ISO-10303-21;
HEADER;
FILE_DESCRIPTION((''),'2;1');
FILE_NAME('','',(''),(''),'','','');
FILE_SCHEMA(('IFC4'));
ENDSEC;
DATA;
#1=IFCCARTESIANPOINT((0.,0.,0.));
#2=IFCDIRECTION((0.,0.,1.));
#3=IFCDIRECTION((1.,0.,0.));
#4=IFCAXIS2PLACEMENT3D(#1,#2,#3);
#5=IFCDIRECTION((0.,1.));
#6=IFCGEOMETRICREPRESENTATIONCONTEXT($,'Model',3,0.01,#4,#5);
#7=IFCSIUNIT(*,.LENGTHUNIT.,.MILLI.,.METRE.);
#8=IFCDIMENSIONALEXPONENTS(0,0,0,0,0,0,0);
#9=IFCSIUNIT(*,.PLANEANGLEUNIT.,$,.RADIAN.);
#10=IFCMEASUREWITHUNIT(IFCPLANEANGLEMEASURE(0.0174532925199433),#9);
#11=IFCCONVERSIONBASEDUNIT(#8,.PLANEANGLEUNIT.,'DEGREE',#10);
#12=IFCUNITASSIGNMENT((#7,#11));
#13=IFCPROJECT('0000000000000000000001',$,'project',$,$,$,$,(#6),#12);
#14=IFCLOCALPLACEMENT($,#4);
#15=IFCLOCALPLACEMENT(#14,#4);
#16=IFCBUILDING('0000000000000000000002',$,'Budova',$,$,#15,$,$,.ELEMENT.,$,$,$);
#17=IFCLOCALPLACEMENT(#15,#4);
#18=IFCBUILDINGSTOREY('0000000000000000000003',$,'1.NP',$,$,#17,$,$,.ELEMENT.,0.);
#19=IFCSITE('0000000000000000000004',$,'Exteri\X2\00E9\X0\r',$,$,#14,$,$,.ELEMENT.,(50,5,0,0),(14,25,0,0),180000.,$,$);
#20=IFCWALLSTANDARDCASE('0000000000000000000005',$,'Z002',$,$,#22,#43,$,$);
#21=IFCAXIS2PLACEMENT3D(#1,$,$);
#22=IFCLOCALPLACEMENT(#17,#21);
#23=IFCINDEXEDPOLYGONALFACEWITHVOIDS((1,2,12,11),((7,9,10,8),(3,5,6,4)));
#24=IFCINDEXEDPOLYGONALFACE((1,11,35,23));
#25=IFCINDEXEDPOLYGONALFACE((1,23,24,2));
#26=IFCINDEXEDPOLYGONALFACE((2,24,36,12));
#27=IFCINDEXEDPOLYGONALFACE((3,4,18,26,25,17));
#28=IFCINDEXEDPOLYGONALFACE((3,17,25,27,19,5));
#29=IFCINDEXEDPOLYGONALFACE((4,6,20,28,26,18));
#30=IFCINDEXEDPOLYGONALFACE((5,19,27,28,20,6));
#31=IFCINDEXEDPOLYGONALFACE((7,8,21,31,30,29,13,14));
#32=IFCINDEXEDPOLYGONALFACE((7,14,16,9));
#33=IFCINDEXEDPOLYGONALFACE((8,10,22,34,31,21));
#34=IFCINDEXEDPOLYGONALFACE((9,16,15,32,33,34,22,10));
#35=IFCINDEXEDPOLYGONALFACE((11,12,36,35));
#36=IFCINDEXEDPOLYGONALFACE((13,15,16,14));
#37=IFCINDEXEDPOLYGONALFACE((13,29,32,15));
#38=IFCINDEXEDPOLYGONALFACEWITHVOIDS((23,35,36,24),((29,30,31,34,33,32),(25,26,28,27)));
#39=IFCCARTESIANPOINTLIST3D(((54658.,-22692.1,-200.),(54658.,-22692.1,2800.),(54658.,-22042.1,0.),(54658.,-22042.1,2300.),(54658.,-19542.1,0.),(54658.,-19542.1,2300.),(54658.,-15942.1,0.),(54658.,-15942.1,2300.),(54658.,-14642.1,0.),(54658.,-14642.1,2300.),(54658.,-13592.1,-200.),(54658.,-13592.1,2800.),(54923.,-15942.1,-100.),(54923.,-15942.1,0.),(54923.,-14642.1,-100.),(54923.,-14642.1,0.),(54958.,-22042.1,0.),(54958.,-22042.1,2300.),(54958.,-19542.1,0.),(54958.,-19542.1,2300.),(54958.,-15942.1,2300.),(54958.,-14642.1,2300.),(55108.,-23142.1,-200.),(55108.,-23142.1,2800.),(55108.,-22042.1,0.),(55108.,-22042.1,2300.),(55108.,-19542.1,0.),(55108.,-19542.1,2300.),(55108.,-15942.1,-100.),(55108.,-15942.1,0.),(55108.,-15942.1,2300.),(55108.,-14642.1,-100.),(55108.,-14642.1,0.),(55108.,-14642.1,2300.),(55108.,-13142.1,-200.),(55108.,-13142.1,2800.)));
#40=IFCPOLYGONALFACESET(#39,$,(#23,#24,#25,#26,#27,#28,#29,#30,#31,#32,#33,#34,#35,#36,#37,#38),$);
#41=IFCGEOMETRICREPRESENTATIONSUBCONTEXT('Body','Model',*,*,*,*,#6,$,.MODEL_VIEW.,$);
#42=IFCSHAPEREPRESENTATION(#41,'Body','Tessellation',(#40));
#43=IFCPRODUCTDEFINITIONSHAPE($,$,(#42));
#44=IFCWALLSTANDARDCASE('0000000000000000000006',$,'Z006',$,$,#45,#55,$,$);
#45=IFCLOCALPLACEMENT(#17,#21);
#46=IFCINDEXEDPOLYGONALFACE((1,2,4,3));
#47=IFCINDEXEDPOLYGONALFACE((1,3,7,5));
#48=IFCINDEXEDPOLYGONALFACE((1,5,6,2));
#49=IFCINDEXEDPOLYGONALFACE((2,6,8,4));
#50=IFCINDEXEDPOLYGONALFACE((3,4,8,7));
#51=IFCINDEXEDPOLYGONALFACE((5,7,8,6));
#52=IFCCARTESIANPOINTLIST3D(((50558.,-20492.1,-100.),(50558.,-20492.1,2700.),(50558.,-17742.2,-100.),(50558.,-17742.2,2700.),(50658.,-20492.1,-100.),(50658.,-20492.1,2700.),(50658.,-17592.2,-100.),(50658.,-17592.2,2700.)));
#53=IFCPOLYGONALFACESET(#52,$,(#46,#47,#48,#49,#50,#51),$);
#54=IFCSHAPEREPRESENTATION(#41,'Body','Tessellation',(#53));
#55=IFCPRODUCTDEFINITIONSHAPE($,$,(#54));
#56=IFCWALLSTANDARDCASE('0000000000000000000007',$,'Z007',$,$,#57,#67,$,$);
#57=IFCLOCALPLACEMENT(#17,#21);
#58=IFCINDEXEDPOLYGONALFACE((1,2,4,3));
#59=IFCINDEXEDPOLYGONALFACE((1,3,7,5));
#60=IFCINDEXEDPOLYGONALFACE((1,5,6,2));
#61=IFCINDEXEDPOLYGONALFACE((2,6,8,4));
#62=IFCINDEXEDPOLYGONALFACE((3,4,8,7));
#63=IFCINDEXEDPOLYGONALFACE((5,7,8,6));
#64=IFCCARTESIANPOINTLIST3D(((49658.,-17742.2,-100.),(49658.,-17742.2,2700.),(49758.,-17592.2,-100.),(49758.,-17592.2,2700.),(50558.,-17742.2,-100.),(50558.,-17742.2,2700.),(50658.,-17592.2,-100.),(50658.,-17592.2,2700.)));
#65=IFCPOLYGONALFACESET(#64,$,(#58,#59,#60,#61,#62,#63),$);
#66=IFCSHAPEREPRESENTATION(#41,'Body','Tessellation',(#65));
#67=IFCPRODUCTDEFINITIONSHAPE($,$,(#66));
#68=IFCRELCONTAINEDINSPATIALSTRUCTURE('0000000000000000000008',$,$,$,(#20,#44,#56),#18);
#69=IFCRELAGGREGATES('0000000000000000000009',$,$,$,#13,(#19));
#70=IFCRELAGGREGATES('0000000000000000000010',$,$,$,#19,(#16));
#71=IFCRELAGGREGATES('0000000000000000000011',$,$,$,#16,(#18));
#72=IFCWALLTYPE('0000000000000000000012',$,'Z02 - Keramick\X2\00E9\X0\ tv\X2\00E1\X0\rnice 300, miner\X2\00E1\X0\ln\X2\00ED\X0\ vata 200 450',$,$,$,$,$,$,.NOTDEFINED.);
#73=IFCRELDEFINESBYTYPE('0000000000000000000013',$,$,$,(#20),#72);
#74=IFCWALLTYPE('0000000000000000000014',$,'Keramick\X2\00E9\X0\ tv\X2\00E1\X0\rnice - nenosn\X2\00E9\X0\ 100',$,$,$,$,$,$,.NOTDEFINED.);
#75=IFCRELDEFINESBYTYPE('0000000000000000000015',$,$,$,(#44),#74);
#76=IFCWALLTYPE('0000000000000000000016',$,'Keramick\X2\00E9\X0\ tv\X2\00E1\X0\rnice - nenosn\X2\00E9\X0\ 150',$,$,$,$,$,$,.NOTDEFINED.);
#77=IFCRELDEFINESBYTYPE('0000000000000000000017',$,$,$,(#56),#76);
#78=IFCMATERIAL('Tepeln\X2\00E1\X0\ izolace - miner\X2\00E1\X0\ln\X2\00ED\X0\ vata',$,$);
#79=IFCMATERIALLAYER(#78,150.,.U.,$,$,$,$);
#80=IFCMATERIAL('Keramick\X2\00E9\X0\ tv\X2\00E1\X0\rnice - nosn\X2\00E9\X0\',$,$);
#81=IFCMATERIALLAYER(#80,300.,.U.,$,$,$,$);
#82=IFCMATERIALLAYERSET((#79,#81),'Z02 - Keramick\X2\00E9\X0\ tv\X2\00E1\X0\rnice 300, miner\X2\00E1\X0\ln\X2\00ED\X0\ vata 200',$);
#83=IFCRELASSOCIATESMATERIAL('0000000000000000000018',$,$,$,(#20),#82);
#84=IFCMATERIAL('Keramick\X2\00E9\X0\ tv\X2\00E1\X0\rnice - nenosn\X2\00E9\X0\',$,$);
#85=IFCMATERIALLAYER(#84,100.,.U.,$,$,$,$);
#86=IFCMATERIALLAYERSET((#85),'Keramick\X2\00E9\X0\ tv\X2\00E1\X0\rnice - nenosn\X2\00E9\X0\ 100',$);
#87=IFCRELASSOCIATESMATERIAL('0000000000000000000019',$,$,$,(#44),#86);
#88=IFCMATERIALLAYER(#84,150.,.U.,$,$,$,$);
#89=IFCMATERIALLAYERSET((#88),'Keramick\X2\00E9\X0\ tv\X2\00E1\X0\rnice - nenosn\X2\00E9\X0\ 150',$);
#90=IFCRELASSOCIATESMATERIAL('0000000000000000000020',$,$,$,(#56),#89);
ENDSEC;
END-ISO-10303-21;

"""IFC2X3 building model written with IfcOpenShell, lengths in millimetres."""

from ifc_helpers import new_model, entity, si_unit, converted_unit, direction, frame, origin_with_axes, origin_2d_with_axis, place, context, subcontext, project, spatial, polyline, rectangle, outline, extrude, material, layer, layer_set, layer_usage, type_object, element, save


model = new_model("IFC2X3")

# Units and contexts
model_context = context("Model", 3, precision=0.01, world=origin_with_axes(), true_north=direction((0.0, 1.0)))
body_context = subcontext(model_context, "Body", "Model", "MODEL_VIEW")
ifc_project = project(units=[si_unit("LENGTHUNIT", "METRE", prefix="MILLI"), converted_unit("PLANEANGLEUNIT", "DEGREE", entity("IfcPlaneAngleMeasure", 0.0174532925199433), si_unit("PLANEANGLEUNIT", "RADIAN"), dimensions=[0, 0, 0, 0, 0, 0, 0])], contexts=[model_context])

# Site, building, storey
site_placement = place(None, origin_with_axes())
site = spatial("IfcSite", under=ifc_project, at=site_placement, Name="Exteriér", CompositionType="ELEMENT", RefLatitude=(50, 5, 0, 0), RefLongitude=(14, 25, 0, 0), RefElevation=180000.0)
building_placement = place(site_placement, origin_with_axes())
building = spatial("IfcBuilding", under=site, at=building_placement, Name="Budova", CompositionType="ELEMENT")
storey_placement = place(building_placement, origin_with_axes())
storey = spatial("IfcBuildingStorey", under=building, at=storey_placement, Name="1.NP", CompositionType="ELEMENT", Elevation=0.0)

# Wall, openings
ifc_material_1 = material(Name="Tepelná izolace - minerální vata")
ifc_layer_1 = layer(ifc_material_1, 150.0, ventilated="UNKNOWN")
ifc_material_2 = material(Name="Keramické tvárnice - nosné")
ifc_layer_2 = layer(ifc_material_2, 300.0, ventilated="UNKNOWN")
ifc_layer_set_1 = layer_set([ifc_layer_1, ifc_layer_2], Name="Z02 - Keramické tvárnice 300, minerální vata 200")
ifc_layer_usage_1 = layer_usage(ifc_layer_set_1, "AXIS2", "NEGATIVE", 0.0)
wall_type_1 = type_object("IfcWallType", Name="Z02 - Keramické tvárnice 300, minerální vata 200 450", PredefinedType="NOTDEFINED")
wall_1_placement = place(storey_placement, frame((55108.0, -13142.1, -200.0), z_axis=(0.0, 0.0, 1.0), x_axis=(0.0, -1.0, 0.0)))
wall_1 = element("IfcWallStandardCase", 1, at=wall_1_placement, inside=storey, type_object=wall_type_1, material=ifc_layer_usage_1, Name="Z002", context=body_context, shape_type="SweptSolid", body=[
    extrude(outline(polyline([(450.0, -450.0), (9550.0, -450.0), (10000.0, 0.0), (0.0, 0.0), (450.0, -450.0)])), origin_with_axes(), (0.0, 0.0, 1.0), 3000.0),
])
opening_1_placement = place(wall_1_placement, frame((2150.0, 0.0, 200.0), z_axis=(0.0, 0.0, 1.0), x_axis=(1.0, 0.0, 0.0)))
element("IfcOpeningElement", 2, at=opening_1_placement, cuts=wall_1, context=body_context, shape_type="SweptSolid", body=[
    extrude(rectangle(XDim=1300.0, YDim=2300.0, at=origin_2d_with_axis()), frame((0.0, -150.0, 1150.0), z_axis=(0.0, 1.0, 0.0), x_axis=(-1.0, 0.0, 0.0)), (0.0, 0.0, -1.0), 750.0),
    extrude(rectangle(XDim=1300.0, YDim=2300.0, at=origin_2d_with_axis()), frame((0.0, -150.0, 1150.0), z_axis=(0.0, -1.0, 0.0), x_axis=(-1.0, 0.0, 0.0)), (0.0, 0.0, -1.0), 600.0),
    extrude(rectangle(XDim=1300.0, YDim=100.0, at=origin_2d_with_axis()), frame((0.0, -185.0, -50.0), z_axis=(0.0, -1.0, 0.0), x_axis=(-1.0, 0.0, 0.0)), (0.0, 0.0, -1.0), 485.0),
])
opening_2_placement = place(wall_1_placement, frame((7650.0, 0.0, 200.0), z_axis=(0.0, 0.0, 1.0), x_axis=(1.0, 0.0, 0.0)))
element("IfcOpeningElement", 3, at=opening_2_placement, cuts=wall_1, context=body_context, shape_type="SweptSolid", body=[
    extrude(rectangle(XDim=2500.0, YDim=2300.0, at=origin_2d_with_axis()), frame((0.0, -150.0, 1150.0), z_axis=(0.0, 1.0, 0.0), x_axis=(-1.0, 0.0, 0.0)), (0.0, 0.0, -1.0), 750.0),
    extrude(rectangle(XDim=2500.0, YDim=2300.0, at=origin_2d_with_axis()), frame((0.0, -150.0, 1150.0), z_axis=(0.0, -1.0, 0.0), x_axis=(-1.0, 0.0, 0.0)), (0.0, 0.0, -1.0), 600.0),
])

# Shared definitions
ifc_material_3 = material(Name="Keramické tvárnice - nenosné")
ifc_layer_3 = layer(ifc_material_3, 100.0, ventilated="UNKNOWN")
ifc_layer_set_2 = layer_set([ifc_layer_3], Name="Keramické tvárnice - nenosné 100")
wall_type_2 = type_object("IfcWallType", Name="Keramické tvárnice - nenosné 100", PredefinedType="NOTDEFINED")

# Wall
ifc_layer_usage_2 = layer_usage(ifc_layer_set_2, "AXIS2", "POSITIVE", 0.0)
wall_2_placement = place(storey_placement, frame((50558.0, -17592.2, -100.0), z_axis=(0.0, 0.0, 1.0), x_axis=(0.0, -1.0, 0.0)))
element("IfcWallStandardCase", 4, at=wall_2_placement, inside=storey, type_object=wall_type_2, material=ifc_layer_usage_2, Name="Z006", context=body_context, shape_type="SweptSolid", body=[
    extrude(outline(polyline([(150.0, 0.0), (2899.8, 0.0), (2899.8, 100.0), (0.0, 100.0), (150.0, 0.0)])), origin_with_axes(), (0.0, 0.0, 1.0), 2800.0),
])

# Wall
ifc_layer_4 = layer(ifc_material_3, 150.0, ventilated="UNKNOWN")
ifc_layer_set_3 = layer_set([ifc_layer_4], Name="Keramické tvárnice - nenosné 150")
ifc_layer_usage_3 = layer_usage(ifc_layer_set_3, "AXIS2", "NEGATIVE", 0.0)
wall_type_3 = type_object("IfcWallType", Name="Keramické tvárnice - nenosné 150", PredefinedType="NOTDEFINED")
wall_3_placement = place(storey_placement, frame((49658.0, -17592.2, -100.0), z_axis=(0.0, 0.0, 1.0), x_axis=(1.0, 0.0, 0.0)))
element("IfcWallStandardCase", 5, at=wall_3_placement, inside=storey, type_object=wall_type_3, material=ifc_layer_usage_3, Name="Z007", context=body_context, shape_type="SweptSolid", body=[
    extrude(outline(polyline([(0.0, -150.0), (900.0, -150.0), (1000.0, 0.0), (100.0, 0.0), (0.0, -150.0)])), origin_with_axes(), (0.0, 0.0, 1.0), 2800.0),
])

save(model, "model.ifc")
